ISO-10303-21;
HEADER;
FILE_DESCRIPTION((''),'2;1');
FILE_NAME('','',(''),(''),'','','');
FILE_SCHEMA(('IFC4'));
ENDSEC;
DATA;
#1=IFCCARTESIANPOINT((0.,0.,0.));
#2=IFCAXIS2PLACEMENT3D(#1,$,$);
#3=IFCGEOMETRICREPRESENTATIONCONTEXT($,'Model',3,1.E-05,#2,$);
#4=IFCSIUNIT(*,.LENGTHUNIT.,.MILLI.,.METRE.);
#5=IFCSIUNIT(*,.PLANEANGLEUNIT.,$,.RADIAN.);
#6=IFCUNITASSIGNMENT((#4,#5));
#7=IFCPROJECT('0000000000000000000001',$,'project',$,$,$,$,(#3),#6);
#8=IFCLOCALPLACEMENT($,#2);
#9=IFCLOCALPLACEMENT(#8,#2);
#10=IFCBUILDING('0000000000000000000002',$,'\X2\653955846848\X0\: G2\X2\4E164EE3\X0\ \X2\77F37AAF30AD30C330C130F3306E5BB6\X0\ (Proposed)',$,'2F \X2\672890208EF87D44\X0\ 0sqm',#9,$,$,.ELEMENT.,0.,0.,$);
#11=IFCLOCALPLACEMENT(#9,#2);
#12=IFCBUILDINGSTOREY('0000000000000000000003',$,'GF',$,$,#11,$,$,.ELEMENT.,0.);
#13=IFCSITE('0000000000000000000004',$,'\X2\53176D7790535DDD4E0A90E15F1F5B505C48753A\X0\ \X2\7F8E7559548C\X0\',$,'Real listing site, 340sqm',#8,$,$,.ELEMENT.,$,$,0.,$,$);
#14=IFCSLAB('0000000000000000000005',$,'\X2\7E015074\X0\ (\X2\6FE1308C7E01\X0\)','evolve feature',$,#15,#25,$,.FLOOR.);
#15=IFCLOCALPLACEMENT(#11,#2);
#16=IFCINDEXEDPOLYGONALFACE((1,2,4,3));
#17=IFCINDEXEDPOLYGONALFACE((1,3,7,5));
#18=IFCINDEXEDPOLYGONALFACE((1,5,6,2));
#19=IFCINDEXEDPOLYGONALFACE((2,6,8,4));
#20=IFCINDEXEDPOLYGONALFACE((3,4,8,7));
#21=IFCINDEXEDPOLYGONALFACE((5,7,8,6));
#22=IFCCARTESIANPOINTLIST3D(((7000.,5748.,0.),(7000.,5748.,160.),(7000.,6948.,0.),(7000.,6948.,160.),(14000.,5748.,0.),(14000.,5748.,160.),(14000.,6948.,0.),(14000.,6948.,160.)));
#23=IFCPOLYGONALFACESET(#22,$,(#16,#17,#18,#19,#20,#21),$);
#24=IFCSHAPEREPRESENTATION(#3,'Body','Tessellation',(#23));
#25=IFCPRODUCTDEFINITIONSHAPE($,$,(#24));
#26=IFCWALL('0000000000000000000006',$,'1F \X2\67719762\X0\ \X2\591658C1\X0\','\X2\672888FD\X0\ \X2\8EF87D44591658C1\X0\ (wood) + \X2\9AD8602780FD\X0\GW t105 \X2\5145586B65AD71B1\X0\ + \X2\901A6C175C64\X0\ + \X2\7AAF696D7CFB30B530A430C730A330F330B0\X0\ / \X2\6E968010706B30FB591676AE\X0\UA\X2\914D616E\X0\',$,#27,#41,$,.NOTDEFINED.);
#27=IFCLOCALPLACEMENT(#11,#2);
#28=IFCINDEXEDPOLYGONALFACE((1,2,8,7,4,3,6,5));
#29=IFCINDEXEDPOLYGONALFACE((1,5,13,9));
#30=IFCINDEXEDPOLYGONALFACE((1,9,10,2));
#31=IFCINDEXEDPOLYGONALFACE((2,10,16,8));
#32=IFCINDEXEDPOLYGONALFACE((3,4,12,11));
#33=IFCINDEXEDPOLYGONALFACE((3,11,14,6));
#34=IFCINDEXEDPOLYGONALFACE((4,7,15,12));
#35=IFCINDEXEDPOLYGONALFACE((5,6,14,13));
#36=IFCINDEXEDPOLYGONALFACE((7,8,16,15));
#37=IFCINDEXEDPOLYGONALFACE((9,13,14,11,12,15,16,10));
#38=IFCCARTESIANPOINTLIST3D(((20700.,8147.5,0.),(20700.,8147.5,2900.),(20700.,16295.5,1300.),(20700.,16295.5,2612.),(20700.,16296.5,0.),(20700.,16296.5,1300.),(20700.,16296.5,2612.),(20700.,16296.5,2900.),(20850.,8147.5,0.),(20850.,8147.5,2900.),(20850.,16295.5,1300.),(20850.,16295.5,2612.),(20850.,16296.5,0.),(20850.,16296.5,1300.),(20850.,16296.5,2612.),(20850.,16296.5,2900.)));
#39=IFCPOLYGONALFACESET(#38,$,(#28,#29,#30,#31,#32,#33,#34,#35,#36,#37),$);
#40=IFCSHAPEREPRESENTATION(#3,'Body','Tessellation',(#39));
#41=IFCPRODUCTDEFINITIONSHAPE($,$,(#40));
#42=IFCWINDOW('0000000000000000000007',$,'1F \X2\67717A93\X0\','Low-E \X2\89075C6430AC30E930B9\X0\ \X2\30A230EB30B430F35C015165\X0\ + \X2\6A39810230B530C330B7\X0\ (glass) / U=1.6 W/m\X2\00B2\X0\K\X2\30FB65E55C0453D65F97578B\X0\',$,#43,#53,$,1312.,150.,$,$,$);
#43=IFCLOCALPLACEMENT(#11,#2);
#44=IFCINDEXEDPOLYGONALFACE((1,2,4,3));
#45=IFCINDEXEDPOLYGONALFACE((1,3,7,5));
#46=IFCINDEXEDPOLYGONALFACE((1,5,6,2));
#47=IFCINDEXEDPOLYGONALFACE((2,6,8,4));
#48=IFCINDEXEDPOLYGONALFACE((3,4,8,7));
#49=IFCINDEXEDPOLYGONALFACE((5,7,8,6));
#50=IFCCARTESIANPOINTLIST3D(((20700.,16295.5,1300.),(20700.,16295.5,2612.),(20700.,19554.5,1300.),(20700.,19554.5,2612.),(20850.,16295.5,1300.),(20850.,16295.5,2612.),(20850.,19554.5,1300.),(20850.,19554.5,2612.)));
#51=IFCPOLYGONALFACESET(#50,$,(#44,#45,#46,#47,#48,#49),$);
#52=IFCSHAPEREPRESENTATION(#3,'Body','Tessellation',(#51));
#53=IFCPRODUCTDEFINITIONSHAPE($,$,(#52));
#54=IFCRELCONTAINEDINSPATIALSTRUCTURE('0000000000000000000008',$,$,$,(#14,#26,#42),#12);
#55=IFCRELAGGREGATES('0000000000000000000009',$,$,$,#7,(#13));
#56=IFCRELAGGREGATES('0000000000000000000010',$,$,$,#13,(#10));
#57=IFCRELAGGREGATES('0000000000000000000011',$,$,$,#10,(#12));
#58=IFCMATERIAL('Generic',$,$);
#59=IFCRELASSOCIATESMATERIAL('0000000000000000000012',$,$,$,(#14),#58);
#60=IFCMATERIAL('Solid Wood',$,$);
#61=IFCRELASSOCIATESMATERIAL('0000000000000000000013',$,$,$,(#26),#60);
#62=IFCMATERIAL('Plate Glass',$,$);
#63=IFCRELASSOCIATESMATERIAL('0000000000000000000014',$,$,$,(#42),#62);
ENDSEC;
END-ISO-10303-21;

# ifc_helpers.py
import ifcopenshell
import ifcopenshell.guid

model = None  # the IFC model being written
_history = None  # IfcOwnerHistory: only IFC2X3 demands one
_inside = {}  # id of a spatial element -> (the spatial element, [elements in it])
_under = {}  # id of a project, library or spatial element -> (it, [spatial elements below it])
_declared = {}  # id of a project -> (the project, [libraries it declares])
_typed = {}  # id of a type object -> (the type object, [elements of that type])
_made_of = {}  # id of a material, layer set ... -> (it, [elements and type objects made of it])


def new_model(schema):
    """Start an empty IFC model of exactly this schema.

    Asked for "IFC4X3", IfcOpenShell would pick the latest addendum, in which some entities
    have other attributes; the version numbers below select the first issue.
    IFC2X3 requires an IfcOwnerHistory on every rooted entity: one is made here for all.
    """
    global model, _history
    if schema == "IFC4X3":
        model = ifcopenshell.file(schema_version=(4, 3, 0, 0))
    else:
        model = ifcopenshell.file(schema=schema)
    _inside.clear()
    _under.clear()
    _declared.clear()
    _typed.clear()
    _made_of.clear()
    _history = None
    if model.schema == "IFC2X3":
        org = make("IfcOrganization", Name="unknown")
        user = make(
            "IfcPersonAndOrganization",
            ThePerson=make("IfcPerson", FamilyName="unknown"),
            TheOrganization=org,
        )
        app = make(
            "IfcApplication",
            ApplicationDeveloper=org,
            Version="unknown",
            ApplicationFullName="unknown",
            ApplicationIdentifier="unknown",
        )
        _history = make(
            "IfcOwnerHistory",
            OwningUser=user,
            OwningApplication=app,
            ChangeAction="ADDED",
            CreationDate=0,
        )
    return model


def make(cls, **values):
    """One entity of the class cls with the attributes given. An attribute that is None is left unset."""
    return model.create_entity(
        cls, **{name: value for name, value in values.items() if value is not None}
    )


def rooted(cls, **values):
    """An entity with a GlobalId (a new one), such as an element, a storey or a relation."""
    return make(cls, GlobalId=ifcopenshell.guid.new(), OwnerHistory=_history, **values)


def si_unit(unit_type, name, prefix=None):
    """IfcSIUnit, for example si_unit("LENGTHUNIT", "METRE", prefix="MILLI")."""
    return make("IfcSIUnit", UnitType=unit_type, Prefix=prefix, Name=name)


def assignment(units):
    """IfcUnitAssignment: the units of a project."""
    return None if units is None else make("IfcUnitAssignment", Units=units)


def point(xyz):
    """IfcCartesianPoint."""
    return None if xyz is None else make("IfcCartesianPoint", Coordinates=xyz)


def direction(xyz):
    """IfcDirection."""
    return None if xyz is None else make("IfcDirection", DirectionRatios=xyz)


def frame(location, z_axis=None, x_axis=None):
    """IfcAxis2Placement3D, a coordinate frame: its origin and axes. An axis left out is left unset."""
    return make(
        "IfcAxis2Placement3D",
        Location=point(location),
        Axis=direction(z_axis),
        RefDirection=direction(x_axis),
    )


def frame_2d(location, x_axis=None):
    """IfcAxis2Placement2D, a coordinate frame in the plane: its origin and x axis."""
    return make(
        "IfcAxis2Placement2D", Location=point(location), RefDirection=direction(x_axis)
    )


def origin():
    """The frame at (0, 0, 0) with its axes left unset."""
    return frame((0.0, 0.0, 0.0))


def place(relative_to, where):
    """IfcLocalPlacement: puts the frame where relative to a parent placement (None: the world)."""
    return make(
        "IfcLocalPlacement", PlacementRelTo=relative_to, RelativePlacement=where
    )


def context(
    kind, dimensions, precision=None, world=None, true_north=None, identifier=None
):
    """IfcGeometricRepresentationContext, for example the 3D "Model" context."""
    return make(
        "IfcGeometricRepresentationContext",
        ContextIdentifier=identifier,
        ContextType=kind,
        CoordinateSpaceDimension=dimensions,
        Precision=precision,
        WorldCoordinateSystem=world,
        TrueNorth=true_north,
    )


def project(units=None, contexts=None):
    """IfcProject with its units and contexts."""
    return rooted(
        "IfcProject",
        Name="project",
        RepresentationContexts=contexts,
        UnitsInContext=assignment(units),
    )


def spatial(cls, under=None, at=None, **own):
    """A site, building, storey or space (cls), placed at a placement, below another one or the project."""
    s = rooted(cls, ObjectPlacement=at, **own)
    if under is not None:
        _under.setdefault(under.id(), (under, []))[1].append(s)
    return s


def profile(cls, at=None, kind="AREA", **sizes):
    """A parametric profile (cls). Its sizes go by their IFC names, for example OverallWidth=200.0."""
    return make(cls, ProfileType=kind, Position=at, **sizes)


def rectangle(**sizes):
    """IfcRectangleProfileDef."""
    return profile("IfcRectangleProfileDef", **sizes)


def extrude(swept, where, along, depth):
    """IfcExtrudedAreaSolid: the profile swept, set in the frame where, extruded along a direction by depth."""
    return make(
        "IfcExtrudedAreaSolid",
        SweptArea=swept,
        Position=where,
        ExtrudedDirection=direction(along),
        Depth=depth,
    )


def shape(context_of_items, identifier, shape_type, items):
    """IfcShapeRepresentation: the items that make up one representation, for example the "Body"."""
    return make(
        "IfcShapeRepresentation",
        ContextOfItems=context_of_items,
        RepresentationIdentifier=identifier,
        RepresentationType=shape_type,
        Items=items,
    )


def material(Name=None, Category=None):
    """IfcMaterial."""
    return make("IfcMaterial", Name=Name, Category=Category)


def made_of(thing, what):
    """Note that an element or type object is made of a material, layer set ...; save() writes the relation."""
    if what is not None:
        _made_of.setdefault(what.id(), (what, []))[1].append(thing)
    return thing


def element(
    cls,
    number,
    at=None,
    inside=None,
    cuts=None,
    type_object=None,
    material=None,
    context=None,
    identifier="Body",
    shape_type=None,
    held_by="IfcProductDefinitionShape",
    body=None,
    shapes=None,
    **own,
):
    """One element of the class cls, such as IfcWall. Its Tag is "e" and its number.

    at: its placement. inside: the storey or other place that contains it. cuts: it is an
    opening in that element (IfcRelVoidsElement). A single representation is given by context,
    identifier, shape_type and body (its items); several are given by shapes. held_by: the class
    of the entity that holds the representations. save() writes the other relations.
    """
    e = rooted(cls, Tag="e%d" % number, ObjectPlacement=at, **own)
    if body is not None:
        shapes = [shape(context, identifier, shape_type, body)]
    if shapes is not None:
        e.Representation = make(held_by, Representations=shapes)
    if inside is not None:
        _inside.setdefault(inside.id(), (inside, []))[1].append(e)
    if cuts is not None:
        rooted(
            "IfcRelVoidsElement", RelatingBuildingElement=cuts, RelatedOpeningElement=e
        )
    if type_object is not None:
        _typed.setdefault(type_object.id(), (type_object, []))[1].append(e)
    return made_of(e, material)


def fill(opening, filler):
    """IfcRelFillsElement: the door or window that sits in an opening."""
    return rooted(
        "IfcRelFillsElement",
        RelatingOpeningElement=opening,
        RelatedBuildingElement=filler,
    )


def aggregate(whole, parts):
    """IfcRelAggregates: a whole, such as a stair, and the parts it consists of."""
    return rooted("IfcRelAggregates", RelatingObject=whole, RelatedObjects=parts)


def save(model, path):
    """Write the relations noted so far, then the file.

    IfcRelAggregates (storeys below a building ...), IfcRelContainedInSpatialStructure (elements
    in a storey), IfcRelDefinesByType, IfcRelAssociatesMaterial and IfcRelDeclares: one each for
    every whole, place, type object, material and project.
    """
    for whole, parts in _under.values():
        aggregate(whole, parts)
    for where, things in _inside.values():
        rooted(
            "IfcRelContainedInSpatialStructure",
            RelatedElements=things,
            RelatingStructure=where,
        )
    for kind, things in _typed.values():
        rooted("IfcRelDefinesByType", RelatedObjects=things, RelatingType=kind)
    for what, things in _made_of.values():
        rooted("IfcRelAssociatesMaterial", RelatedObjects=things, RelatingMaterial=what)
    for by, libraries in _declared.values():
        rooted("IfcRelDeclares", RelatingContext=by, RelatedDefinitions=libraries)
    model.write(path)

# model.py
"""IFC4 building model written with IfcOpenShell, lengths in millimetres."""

from ifc_helpers import new_model, si_unit, frame, frame_2d, origin, place, context, project, spatial, rectangle, extrude, material, element, fill, save


model = new_model("IFC4")

# Units and contexts
model_context = context("Model", 3, precision=1e-05, world=origin())
ifc_project = project(units=[si_unit("LENGTHUNIT", "METRE", prefix="MILLI"), si_unit("PLANEANGLEUNIT", "RADIAN")], contexts=[model_context])

# Site, building, storey
site_placement = place(None, origin())
site = spatial("IfcSite", under=ifc_project, at=site_placement, Name="北海道川上郡弟子屈町 美留和", ObjectType="Real listing site, 340sqm", CompositionType="ELEMENT", RefElevation=0.0)
building_placement = place(site_placement, origin())
building = spatial("IfcBuilding", under=site, at=building_placement, Name="改善案: G2世代 石窯キッチンの家 (Proposed)", ObjectType="2F 木造軸組 0sqm", CompositionType="ELEMENT", ElevationOfRefHeight=0.0, ElevationOfTerrain=0.0)
storey_placement = place(building_placement, origin())
storey = spatial("IfcBuildingStorey", under=building, at=storey_placement, Name="GF", CompositionType="ELEMENT", Elevation=0.0)

# Slab
ifc_material_1 = material(Name="Solid Wood")
ifc_material_2 = material(Name="Generic")
slab_1_placement = place(storey_placement, frame((3500.0, 2874.0, 0.0)))
element("IfcSlab", 1, at=slab_1_placement, inside=storey, material=ifc_material_2, Name="縁側 (濡れ縁)", Description="evolve feature", PredefinedType="FLOOR", context=model_context, shape_type="SweptSolid", body=[
    extrude(rectangle(XDim=7000.0, YDim=1200.0, at=frame_2d((3500.0, 600.0))), frame((3500.0, 2874.0, 0.0)), (0.0, 0.0, 1.0), 160.0),
])

# Shared definitions
ifc_material_3 = material(Name="Plate Glass")

# Wall, opening, window
wall_1_placement = place(storey_placement, frame((10350.0, 4074.0, 0.0)))
wall_1 = element("IfcWall", 2, at=wall_1_placement, inside=storey, material=ifc_material_1, Name="1F 東面 外壁", Description="木製 軸組外壁 (wood) + 高性能GW t105 充填断熱 + 通気層 + 窯業系サイディング / 準耐火・外皮UA配慮", PredefinedType="NOTDEFINED", context=model_context, shape_type="SweptSolid", body=[
    extrude(rectangle(XDim=150.0, YDim=8149.0, at=frame_2d((75.0, 4074.0))), frame((10350.0, 4074.0, 0.0)), (0.0, 0.0, 1.0), 2900.0),
])
opening_1_placement = place(storey_placement, frame((10350.0, 8148.0, 650.0)))
opening_1 = element("IfcOpeningElement", 3, at=opening_1_placement, cuts=wall_1, PredefinedType="NOTDEFINED", context=model_context, shape_type="SweptSolid", body=[
    extrude(rectangle(XDim=150.0, YDim=3259.0, at=frame_2d((75.0, 1629.0))), frame((10350.0, 8148.0, 650.0)), (0.0, 0.0, 1.0), 1312.0),
])
window_1_placement = place(storey_placement, frame((10350.0, 8148.0, 650.0)))
window_1 = element("IfcWindow", 4, at=window_1_placement, inside=storey, material=ifc_material_3, Name="1F 東窓", Description="Low-E 複層ガラス アルゴン封入 + 樹脂サッシ (glass) / U=1.6 W/m²K・日射取得型", OverallHeight=1312.0, OverallWidth=150.0, context=model_context, shape_type="SweptSolid", body=[
    extrude(rectangle(XDim=150.0, YDim=3259.0, at=frame_2d((75.0, 1629.0))), frame((10350.0, 8148.0, 650.0)), (0.0, 0.0, 1.0), 1312.0),
])
fill(opening_1, window_1)

save(model, "model.ifc")
